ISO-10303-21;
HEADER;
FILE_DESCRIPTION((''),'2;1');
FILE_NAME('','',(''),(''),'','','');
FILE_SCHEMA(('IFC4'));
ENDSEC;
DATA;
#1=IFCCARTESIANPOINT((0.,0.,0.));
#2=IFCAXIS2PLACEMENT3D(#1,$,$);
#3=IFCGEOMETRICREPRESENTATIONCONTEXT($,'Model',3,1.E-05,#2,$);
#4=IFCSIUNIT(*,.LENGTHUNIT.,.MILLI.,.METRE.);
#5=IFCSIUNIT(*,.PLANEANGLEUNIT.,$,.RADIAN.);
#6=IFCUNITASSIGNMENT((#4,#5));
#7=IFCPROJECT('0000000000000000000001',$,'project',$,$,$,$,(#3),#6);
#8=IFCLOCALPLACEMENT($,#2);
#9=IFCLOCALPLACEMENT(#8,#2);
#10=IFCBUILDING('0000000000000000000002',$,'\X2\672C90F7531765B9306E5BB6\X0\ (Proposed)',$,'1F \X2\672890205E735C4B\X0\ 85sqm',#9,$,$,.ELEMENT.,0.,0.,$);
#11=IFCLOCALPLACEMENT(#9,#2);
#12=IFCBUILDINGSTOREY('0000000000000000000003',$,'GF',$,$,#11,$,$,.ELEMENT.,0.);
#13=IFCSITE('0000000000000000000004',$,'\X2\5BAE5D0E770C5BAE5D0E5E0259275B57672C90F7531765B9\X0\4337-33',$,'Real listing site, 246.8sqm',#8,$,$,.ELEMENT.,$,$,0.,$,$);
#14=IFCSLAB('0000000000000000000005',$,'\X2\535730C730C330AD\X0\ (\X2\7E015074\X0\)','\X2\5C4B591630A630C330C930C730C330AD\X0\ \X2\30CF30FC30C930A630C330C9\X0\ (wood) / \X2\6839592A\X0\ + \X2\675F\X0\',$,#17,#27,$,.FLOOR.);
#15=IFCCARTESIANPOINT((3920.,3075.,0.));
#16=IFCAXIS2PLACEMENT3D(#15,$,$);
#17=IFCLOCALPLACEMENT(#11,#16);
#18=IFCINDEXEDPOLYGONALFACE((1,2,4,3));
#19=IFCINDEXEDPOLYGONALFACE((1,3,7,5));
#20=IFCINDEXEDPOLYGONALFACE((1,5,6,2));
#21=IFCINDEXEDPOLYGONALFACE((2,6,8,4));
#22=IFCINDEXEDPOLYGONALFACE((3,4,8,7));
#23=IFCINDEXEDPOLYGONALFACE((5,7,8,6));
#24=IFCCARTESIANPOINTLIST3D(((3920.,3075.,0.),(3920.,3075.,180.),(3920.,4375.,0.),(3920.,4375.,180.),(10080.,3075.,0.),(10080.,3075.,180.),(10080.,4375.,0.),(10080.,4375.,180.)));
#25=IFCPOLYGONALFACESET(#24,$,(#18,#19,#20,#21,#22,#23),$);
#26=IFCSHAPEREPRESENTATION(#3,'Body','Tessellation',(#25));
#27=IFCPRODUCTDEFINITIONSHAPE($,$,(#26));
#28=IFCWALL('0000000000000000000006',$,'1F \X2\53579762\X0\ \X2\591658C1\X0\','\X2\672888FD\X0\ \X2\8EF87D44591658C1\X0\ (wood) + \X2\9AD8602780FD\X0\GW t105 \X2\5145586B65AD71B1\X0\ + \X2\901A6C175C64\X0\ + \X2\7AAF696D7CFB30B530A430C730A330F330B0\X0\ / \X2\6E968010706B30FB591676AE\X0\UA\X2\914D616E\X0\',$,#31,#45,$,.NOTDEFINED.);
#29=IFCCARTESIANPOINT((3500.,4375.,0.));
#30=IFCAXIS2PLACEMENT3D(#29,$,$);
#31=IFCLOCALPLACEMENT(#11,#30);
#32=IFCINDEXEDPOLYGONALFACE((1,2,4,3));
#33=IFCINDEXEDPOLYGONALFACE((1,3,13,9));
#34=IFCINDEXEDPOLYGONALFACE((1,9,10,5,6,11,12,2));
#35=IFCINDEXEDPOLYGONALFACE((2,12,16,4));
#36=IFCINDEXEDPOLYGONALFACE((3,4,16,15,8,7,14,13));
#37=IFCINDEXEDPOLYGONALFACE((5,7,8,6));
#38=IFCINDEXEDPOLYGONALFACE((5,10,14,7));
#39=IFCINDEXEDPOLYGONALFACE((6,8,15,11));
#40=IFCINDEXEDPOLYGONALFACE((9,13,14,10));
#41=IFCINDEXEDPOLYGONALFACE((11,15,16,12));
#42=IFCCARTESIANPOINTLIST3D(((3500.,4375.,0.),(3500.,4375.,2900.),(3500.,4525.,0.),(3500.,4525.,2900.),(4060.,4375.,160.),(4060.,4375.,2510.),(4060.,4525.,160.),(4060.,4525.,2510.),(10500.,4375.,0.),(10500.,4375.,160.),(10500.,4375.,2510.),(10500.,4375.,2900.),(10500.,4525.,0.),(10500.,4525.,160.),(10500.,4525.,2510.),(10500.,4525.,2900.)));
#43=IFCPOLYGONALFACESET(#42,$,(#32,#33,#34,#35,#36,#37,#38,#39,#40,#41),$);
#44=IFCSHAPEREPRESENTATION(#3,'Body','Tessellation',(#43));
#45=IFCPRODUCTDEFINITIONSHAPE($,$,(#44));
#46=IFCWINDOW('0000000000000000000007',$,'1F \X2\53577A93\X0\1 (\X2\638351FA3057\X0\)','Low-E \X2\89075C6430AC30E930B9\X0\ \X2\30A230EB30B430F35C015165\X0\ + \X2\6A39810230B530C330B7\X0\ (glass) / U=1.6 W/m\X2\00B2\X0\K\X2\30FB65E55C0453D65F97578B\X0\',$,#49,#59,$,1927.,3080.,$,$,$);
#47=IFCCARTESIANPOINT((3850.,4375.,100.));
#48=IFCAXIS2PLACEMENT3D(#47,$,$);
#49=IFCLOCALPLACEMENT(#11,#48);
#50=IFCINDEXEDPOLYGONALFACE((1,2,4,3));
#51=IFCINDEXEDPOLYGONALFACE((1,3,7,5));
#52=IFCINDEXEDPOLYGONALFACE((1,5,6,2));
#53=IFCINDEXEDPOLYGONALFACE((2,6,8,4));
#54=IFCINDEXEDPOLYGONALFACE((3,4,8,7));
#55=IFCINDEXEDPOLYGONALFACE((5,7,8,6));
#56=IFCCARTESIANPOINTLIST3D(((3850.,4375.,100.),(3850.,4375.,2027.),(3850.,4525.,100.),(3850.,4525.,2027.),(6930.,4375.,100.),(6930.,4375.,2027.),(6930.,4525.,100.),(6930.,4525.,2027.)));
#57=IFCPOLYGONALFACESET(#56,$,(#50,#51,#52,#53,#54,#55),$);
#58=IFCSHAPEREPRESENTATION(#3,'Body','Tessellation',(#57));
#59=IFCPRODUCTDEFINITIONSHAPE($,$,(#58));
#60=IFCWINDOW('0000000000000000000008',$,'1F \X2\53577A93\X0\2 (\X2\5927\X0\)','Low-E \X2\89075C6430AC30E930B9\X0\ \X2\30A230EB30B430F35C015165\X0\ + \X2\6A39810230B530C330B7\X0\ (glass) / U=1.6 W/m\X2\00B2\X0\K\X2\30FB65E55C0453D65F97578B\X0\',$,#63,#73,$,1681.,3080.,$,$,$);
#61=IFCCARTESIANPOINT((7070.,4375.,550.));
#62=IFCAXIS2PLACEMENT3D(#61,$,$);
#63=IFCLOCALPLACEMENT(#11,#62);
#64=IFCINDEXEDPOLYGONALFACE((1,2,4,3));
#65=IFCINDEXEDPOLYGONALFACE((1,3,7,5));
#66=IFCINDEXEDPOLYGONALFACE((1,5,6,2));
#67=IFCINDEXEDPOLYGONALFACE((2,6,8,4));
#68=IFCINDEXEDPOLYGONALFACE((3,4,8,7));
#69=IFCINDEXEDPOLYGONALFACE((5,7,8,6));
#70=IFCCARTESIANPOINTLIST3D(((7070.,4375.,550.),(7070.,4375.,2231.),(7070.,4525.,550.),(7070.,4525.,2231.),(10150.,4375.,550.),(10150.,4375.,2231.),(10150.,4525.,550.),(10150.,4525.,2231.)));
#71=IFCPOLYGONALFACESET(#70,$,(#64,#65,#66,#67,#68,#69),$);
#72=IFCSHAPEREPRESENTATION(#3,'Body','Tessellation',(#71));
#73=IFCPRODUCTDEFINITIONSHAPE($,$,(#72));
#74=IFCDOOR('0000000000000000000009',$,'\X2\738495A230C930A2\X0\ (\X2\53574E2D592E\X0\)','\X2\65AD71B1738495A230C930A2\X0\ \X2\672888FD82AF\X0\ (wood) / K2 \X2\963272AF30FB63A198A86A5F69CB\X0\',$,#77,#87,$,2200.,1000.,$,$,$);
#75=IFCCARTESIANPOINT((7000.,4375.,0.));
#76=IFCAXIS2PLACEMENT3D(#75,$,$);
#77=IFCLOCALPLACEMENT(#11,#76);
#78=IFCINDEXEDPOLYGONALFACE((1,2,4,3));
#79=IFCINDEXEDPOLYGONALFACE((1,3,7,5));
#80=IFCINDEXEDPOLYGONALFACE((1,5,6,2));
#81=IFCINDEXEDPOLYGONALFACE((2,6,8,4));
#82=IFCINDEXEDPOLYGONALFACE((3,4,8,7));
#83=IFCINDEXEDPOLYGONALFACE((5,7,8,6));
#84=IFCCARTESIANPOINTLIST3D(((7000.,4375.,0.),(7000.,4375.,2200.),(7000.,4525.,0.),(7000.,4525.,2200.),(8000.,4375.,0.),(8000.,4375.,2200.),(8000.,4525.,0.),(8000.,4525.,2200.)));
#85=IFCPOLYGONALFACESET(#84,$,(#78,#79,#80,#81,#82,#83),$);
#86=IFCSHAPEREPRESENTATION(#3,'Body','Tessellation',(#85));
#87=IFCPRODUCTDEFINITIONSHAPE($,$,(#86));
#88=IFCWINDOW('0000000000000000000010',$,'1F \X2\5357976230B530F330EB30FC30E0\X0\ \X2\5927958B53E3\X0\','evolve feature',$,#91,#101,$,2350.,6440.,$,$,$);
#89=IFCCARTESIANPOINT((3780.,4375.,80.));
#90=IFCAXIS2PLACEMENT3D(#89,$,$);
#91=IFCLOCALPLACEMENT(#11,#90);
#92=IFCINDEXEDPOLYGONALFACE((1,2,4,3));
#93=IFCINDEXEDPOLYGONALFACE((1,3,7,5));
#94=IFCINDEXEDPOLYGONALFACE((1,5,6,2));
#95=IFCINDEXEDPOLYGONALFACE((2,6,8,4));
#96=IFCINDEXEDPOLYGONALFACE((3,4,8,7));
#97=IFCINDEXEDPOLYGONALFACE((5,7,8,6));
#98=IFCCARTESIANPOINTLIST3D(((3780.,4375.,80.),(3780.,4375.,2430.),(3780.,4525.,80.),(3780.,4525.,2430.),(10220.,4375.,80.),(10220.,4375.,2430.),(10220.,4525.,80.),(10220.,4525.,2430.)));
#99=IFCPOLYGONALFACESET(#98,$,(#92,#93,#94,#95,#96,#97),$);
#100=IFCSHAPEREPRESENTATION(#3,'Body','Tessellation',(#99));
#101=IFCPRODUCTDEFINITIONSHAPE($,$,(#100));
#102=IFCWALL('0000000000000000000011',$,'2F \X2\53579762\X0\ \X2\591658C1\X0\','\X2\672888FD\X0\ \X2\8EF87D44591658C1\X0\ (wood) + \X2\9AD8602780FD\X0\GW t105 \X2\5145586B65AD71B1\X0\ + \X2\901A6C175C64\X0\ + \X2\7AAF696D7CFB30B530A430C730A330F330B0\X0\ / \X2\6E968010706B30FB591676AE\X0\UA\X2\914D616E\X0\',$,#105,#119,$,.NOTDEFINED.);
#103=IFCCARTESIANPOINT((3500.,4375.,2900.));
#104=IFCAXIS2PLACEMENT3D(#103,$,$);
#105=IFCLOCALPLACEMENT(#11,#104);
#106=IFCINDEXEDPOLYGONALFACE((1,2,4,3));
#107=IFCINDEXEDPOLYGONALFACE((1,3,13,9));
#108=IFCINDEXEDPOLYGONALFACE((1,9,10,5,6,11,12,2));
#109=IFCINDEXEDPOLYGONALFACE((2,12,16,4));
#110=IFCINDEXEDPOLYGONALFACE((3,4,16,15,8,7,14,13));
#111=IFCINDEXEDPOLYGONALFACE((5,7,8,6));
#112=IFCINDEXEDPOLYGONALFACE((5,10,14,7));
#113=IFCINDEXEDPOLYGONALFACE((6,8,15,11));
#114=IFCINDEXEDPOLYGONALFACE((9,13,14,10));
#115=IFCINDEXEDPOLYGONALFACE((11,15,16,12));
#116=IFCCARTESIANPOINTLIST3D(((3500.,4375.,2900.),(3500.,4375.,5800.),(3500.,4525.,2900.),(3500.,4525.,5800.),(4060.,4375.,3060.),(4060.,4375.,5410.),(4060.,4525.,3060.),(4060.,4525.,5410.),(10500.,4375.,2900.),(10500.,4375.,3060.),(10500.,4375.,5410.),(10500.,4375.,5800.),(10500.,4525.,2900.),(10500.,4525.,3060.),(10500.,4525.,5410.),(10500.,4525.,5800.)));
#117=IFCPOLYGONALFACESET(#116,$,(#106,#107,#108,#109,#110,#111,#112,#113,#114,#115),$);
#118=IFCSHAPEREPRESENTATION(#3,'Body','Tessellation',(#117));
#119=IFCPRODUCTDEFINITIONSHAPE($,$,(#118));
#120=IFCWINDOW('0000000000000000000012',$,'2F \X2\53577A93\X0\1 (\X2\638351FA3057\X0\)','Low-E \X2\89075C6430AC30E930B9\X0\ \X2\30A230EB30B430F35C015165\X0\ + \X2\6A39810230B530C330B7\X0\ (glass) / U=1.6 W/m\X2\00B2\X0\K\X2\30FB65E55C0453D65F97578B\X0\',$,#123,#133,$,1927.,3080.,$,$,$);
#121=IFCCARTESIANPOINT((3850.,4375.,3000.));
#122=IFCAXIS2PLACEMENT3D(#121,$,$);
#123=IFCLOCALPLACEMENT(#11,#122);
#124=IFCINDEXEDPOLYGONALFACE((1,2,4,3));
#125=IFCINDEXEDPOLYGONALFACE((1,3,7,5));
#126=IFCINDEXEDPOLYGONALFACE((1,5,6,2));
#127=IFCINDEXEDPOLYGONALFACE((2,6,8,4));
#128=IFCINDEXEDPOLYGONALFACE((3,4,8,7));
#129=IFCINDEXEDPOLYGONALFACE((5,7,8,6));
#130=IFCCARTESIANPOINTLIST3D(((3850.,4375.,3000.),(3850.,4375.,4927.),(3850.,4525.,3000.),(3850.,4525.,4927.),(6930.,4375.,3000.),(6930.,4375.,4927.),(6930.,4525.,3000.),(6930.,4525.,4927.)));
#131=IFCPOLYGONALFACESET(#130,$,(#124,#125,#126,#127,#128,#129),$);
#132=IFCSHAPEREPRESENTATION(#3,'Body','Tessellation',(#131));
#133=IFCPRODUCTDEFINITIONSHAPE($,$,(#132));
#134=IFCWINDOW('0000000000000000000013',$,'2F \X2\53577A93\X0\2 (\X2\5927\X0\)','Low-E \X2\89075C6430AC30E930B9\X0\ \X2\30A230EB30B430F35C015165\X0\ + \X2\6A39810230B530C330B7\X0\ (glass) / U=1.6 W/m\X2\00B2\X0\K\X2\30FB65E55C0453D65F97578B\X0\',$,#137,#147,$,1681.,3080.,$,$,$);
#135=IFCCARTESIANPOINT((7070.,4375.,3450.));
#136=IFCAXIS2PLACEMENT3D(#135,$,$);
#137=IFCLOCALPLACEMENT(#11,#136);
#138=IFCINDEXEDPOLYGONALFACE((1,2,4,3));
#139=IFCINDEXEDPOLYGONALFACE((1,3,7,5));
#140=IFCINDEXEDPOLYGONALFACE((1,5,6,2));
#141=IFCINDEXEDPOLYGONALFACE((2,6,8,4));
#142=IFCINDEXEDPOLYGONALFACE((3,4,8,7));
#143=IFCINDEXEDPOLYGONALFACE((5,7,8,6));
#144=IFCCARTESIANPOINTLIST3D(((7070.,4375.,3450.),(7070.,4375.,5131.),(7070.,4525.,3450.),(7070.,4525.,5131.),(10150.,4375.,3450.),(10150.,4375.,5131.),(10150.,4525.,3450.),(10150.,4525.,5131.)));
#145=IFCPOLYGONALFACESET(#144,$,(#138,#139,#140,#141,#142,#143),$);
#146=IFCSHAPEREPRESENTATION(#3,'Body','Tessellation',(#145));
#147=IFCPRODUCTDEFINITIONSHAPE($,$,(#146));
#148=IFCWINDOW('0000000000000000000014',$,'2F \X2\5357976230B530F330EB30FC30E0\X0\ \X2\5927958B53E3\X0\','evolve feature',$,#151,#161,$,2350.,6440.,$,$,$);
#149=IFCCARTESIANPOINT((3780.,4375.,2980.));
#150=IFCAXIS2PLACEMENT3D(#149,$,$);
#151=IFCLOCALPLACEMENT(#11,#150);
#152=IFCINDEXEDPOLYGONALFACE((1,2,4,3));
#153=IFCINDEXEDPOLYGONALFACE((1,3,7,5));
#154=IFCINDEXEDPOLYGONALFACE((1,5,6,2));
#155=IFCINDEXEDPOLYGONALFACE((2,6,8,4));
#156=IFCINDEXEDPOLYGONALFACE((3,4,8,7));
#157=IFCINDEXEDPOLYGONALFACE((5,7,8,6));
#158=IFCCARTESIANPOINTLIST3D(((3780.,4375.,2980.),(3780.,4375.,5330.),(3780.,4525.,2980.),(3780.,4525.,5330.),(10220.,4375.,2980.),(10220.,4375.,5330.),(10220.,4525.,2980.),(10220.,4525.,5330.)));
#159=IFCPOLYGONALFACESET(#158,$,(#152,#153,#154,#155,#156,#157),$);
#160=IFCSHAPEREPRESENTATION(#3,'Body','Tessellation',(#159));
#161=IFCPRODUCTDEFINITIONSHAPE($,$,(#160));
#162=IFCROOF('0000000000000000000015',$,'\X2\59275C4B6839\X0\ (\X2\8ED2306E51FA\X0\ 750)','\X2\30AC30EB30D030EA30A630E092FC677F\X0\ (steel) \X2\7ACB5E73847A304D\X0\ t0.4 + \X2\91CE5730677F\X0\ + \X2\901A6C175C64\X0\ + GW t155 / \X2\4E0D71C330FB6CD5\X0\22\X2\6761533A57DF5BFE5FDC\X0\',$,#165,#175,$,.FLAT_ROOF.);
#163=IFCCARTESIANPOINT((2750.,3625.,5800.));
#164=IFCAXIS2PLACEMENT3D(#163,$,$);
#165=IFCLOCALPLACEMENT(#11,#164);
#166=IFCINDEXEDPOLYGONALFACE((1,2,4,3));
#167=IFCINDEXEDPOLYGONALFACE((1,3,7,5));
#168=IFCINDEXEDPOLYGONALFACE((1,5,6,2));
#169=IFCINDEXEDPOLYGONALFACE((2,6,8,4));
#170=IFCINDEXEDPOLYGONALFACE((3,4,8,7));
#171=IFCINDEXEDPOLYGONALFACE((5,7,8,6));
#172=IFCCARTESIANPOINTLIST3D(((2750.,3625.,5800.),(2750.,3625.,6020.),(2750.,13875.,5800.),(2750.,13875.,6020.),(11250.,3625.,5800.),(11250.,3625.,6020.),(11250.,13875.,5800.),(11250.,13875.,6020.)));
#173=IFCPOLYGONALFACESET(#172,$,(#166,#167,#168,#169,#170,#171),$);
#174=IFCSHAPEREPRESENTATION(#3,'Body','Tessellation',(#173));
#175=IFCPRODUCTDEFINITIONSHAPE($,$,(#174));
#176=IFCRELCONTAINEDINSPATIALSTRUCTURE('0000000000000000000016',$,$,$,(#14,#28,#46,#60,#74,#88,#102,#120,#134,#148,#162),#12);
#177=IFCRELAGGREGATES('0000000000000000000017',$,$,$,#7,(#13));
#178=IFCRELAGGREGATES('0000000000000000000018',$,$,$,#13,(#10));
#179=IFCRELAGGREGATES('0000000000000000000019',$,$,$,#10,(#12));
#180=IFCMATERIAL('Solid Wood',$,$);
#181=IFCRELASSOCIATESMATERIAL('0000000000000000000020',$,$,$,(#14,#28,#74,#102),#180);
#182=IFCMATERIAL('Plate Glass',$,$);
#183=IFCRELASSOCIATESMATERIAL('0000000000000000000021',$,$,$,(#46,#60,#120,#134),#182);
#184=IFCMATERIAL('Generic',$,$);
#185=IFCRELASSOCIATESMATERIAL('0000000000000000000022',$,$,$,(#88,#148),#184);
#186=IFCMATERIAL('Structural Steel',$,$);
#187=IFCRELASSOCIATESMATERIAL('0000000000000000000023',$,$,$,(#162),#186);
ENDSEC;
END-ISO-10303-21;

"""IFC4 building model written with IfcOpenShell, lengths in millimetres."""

from ifc_helpers import new_model, si_unit, frame, frame_2d, origin, place, context, project, spatial, rectangle, extrude, material, element, fill, save


model = new_model("IFC4")

# Units and contexts
model_context = context("Model", 3, precision=1e-05, world=origin())
ifc_project = project(units=[si_unit("LENGTHUNIT", "METRE", prefix="MILLI"), si_unit("PLANEANGLEUNIT", "RADIAN")], contexts=[model_context])

# Site, building, storey
site_placement = place(None, origin())
site = spatial("IfcSite", under=ifc_project, at=site_placement, Name="宮崎県宮崎市大字本郷北方4337-33", ObjectType="Real listing site, 246.8sqm", CompositionType="ELEMENT", RefElevation=0.0)
building_placement = place(site_placement, origin())
building = spatial("IfcBuilding", under=site, at=building_placement, Name="本郷北方の家 (Proposed)", ObjectType="1F 木造平屋 85sqm", CompositionType="ELEMENT", ElevationOfRefHeight=0.0, ElevationOfTerrain=0.0)
storey_placement = place(building_placement, origin())
storey = spatial("IfcBuildingStorey", under=building, at=storey_placement, Name="GF", CompositionType="ELEMENT", Elevation=0.0)

# Slab
ifc_material_1 = material(Name="Solid Wood")
slab_1_placement = place(storey_placement, frame((3920.0, 3075.0, 0.0)))
element("IfcSlab", 1, at=slab_1_placement, inside=storey, material=ifc_material_1, Name="南デッキ (縁側)", Description="屋外ウッドデッキ ハードウッド (wood) / 根太 + 束", PredefinedType="FLOOR", context=model_context, shape_type="SweptSolid", body=[
    extrude(rectangle(XDim=6160.0, YDim=1300.0, at=frame_2d((3080.0, 650.0))), frame((3920.0, 3075.0, 0.0)), (0.0, 0.0, 1.0), 180.0),
])
ifc_material_2 = material(Name="Generic")

# Wall, openings, windows, door
wall_1_placement = place(storey_placement, frame((3500.0, 4375.0, 0.0)))
wall_1 = element("IfcWall", 2, at=wall_1_placement, inside=storey, material=ifc_material_1, Name="1F 南面 外壁", Description="木製 軸組外壁 (wood) + 高性能GW t105 充填断熱 + 通気層 + 窯業系サイディング / 準耐火・外皮UA配慮", PredefinedType="NOTDEFINED", context=model_context, shape_type="SweptSolid", body=[
    extrude(rectangle(XDim=7000.0, YDim=150.0, at=frame_2d((3500.0, 75.0))), frame((3500.0, 4375.0, 0.0)), (0.0, 0.0, 1.0), 2900.0),
])
opening_1_placement = place(storey_placement, frame((3850.0, 4375.0, 100.0)))
opening_1 = element("IfcOpeningElement", 3, at=opening_1_placement, cuts=wall_1, PredefinedType="NOTDEFINED", context=model_context, shape_type="SweptSolid", body=[
    extrude(rectangle(XDim=3080.0, YDim=150.0, at=frame_2d((1540.0, 75.0))), frame((3850.0, 4375.0, 100.0)), (0.0, 0.0, 1.0), 1927.0),
])
opening_2_placement = place(storey_placement, frame((7070.0, 4375.0, 550.0)))
opening_2 = element("IfcOpeningElement", 4, at=opening_2_placement, cuts=wall_1, PredefinedType="NOTDEFINED", context=model_context, shape_type="SweptSolid", body=[
    extrude(rectangle(XDim=3080.0, YDim=150.0, at=frame_2d((1540.0, 75.0))), frame((7070.0, 4375.0, 550.0)), (0.0, 0.0, 1.0), 1681.0),
])
opening_3_placement = place(storey_placement, frame((7000.0, 4375.0, 0.0)))
opening_3 = element("IfcOpeningElement", 5, at=opening_3_placement, cuts=wall_1, PredefinedType="NOTDEFINED", context=model_context, shape_type="SweptSolid", body=[
    extrude(rectangle(XDim=1000.0, YDim=150.0, at=frame_2d((500.0, 75.0))), frame((7000.0, 4375.0, 0.0)), (0.0, 0.0, 1.0), 2200.0),
])
opening_4_placement = place(storey_placement, frame((3780.0, 4375.0, 80.0)))
opening_4 = element("IfcOpeningElement", 6, at=opening_4_placement, cuts=wall_1, PredefinedType="NOTDEFINED", context=model_context, shape_type="SweptSolid", body=[
    extrude(rectangle(XDim=6440.0, YDim=150.0, at=frame_2d((3220.0, 75.0))), frame((3780.0, 4375.0, 80.0)), (0.0, 0.0, 1.0), 2350.0),
])
ifc_material_3 = material(Name="Plate Glass")
window_1_placement = place(storey_placement, frame((3850.0, 4375.0, 100.0)))
window_1 = element("IfcWindow", 7, at=window_1_placement, inside=storey, material=ifc_material_3, Name="1F 南窓1 (掃出し)", Description="Low-E 複層ガラス アルゴン封入 + 樹脂サッシ (glass) / U=1.6 W/m²K・日射取得型", OverallHeight=1927.0, OverallWidth=3080.0, context=model_context, shape_type="SweptSolid", body=[
    extrude(rectangle(XDim=3080.0, YDim=150.0, at=frame_2d((1540.0, 75.0))), frame((3850.0, 4375.0, 100.0)), (0.0, 0.0, 1.0), 1927.0),
])
fill(opening_1, window_1)
window_2_placement = place(storey_placement, frame((7070.0, 4375.0, 550.0)))
window_2 = element("IfcWindow", 8, at=window_2_placement, inside=storey, material=ifc_material_3, Name="1F 南窓2 (大)", Description="Low-E 複層ガラス アルゴン封入 + 樹脂サッシ (glass) / U=1.6 W/m²K・日射取得型", OverallHeight=1681.0, OverallWidth=3080.0, context=model_context, shape_type="SweptSolid", body=[
    extrude(rectangle(XDim=3080.0, YDim=150.0, at=frame_2d((1540.0, 75.0))), frame((7070.0, 4375.0, 550.0)), (0.0, 0.0, 1.0), 1681.0),
])
fill(opening_2, window_2)
door_placement = place(storey_placement, frame((7000.0, 4375.0, 0.0)))
door = element("IfcDoor", 9, at=door_placement, inside=storey, material=ifc_material_1, Name="玄関ドア (南中央)", Description="断熱玄関ドア 木製芯 (wood) / K2 防犯・採風機構", OverallHeight=2200.0, OverallWidth=1000.0, context=model_context, shape_type="SweptSolid", body=[
    extrude(rectangle(XDim=1000.0, YDim=150.0, at=frame_2d((500.0, 75.0))), frame((7000.0, 4375.0, 0.0)), (0.0, 0.0, 1.0), 2200.0),
])
fill(opening_3, door)
window_3_placement = place(storey_placement, frame((3780.0, 4375.0, 80.0)))
window_3 = element("IfcWindow", 10, at=window_3_placement, inside=storey, material=ifc_material_2, Name="1F 南面サンルーム 大開口", Description="evolve feature", OverallHeight=2350.0, OverallWidth=6440.0, context=model_context, shape_type="SweptSolid", body=[
    extrude(rectangle(XDim=6440.0, YDim=150.0, at=frame_2d((3220.0, 75.0))), frame((3780.0, 4375.0, 80.0)), (0.0, 0.0, 1.0), 2350.0),
])
fill(opening_4, window_3)

# Wall, openings, windows
wall_2_placement = place(storey_placement, frame((3500.0, 4375.0, 2900.0)))
wall_2 = element("IfcWall", 11, at=wall_2_placement, inside=storey, material=ifc_material_1, Name="2F 南面 外壁", Description="木製 軸組外壁 (wood) + 高性能GW t105 充填断熱 + 通気層 + 窯業系サイディング / 準耐火・外皮UA配慮", PredefinedType="NOTDEFINED", context=model_context, shape_type="SweptSolid", body=[
    extrude(rectangle(XDim=7000.0, YDim=150.0, at=frame_2d((3500.0, 75.0))), frame((3500.0, 4375.0, 2900.0)), (0.0, 0.0, 1.0), 2900.0),
])
opening_5_placement = place(storey_placement, frame((3850.0, 4375.0, 3000.0)))
opening_5 = element("IfcOpeningElement", 12, at=opening_5_placement, cuts=wall_2, PredefinedType="NOTDEFINED", context=model_context, shape_type="SweptSolid", body=[
    extrude(rectangle(XDim=3080.0, YDim=150.0, at=frame_2d((1540.0, 75.0))), frame((3850.0, 4375.0, 3000.0)), (0.0, 0.0, 1.0), 1927.0),
])
opening_6_placement = place(storey_placement, frame((7070.0, 4375.0, 3450.0)))
opening_6 = element("IfcOpeningElement", 13, at=opening_6_placement, cuts=wall_2, PredefinedType="NOTDEFINED", context=model_context, shape_type="SweptSolid", body=[
    extrude(rectangle(XDim=3080.0, YDim=150.0, at=frame_2d((1540.0, 75.0))), frame((7070.0, 4375.0, 3450.0)), (0.0, 0.0, 1.0), 1681.0),
])
opening_7_placement = place(storey_placement, frame((3780.0, 4375.0, 2980.0)))
opening_7 = element("IfcOpeningElement", 14, at=opening_7_placement, cuts=wall_2, PredefinedType="NOTDEFINED", context=model_context, shape_type="SweptSolid", body=[
    extrude(rectangle(XDim=6440.0, YDim=150.0, at=frame_2d((3220.0, 75.0))), frame((3780.0, 4375.0, 2980.0)), (0.0, 0.0, 1.0), 2350.0),
])
window_4_placement = place(storey_placement, frame((3850.0, 4375.0, 3000.0)))
window_4 = element("IfcWindow", 15, at=window_4_placement, inside=storey, material=ifc_material_3, Name="2F 南窓1 (掃出し)", Description="Low-E 複層ガラス アルゴン封入 + 樹脂サッシ (glass) / U=1.6 W/m²K・日射取得型", OverallHeight=1927.0, OverallWidth=3080.0, context=model_context, shape_type="SweptSolid", body=[
    extrude(rectangle(XDim=3080.0, YDim=150.0, at=frame_2d((1540.0, 75.0))), frame((3850.0, 4375.0, 3000.0)), (0.0, 0.0, 1.0), 1927.0),
])
fill(opening_5, window_4)
window_5_placement = place(storey_placement, frame((7070.0, 4375.0, 3450.0)))
window_5 = element("IfcWindow", 16, at=window_5_placement, inside=storey, material=ifc_material_3, Name="2F 南窓2 (大)", Description="Low-E 複層ガラス アルゴン封入 + 樹脂サッシ (glass) / U=1.6 W/m²K・日射取得型", OverallHeight=1681.0, OverallWidth=3080.0, context=model_context, shape_type="SweptSolid", body=[
    extrude(rectangle(XDim=3080.0, YDim=150.0, at=frame_2d((1540.0, 75.0))), frame((7070.0, 4375.0, 3450.0)), (0.0, 0.0, 1.0), 1681.0),
])
fill(opening_6, window_5)
window_6_placement = place(storey_placement, frame((3780.0, 4375.0, 2980.0)))
window_6 = element("IfcWindow", 17, at=window_6_placement, inside=storey, material=ifc_material_2, Name="2F 南面サンルーム 大開口", Description="evolve feature", OverallHeight=2350.0, OverallWidth=6440.0, context=model_context, shape_type="SweptSolid", body=[
    extrude(rectangle(XDim=6440.0, YDim=150.0, at=frame_2d((3220.0, 75.0))), frame((3780.0, 4375.0, 2980.0)), (0.0, 0.0, 1.0), 2350.0),
])
fill(opening_7, window_6)

# Roof
ifc_material_4 = material(Name="Structural Steel")
roof_placement = place(storey_placement, frame((2750.0, 3625.0, 5800.0)))
element("IfcRoof", 18, at=roof_placement, inside=storey, material=ifc_material_4, Name="大屋根 (軒の出 750)", Description="ガルバリウム鋼板 (steel) 立平葺き t0.4 + 野地板 + 通気層 + GW t155 / 不燃・法22条区域対応", PredefinedType="FLAT_ROOF", context=model_context, shape_type="SweptSolid", body=[
    extrude(rectangle(XDim=8500.0, YDim=10250.0, at=frame_2d((4250.0, 5125.0))), frame((2750.0, 3625.0, 5800.0)), (0.0, 0.0, 1.0), 220.0),
])

save(model, "model.ifc")
